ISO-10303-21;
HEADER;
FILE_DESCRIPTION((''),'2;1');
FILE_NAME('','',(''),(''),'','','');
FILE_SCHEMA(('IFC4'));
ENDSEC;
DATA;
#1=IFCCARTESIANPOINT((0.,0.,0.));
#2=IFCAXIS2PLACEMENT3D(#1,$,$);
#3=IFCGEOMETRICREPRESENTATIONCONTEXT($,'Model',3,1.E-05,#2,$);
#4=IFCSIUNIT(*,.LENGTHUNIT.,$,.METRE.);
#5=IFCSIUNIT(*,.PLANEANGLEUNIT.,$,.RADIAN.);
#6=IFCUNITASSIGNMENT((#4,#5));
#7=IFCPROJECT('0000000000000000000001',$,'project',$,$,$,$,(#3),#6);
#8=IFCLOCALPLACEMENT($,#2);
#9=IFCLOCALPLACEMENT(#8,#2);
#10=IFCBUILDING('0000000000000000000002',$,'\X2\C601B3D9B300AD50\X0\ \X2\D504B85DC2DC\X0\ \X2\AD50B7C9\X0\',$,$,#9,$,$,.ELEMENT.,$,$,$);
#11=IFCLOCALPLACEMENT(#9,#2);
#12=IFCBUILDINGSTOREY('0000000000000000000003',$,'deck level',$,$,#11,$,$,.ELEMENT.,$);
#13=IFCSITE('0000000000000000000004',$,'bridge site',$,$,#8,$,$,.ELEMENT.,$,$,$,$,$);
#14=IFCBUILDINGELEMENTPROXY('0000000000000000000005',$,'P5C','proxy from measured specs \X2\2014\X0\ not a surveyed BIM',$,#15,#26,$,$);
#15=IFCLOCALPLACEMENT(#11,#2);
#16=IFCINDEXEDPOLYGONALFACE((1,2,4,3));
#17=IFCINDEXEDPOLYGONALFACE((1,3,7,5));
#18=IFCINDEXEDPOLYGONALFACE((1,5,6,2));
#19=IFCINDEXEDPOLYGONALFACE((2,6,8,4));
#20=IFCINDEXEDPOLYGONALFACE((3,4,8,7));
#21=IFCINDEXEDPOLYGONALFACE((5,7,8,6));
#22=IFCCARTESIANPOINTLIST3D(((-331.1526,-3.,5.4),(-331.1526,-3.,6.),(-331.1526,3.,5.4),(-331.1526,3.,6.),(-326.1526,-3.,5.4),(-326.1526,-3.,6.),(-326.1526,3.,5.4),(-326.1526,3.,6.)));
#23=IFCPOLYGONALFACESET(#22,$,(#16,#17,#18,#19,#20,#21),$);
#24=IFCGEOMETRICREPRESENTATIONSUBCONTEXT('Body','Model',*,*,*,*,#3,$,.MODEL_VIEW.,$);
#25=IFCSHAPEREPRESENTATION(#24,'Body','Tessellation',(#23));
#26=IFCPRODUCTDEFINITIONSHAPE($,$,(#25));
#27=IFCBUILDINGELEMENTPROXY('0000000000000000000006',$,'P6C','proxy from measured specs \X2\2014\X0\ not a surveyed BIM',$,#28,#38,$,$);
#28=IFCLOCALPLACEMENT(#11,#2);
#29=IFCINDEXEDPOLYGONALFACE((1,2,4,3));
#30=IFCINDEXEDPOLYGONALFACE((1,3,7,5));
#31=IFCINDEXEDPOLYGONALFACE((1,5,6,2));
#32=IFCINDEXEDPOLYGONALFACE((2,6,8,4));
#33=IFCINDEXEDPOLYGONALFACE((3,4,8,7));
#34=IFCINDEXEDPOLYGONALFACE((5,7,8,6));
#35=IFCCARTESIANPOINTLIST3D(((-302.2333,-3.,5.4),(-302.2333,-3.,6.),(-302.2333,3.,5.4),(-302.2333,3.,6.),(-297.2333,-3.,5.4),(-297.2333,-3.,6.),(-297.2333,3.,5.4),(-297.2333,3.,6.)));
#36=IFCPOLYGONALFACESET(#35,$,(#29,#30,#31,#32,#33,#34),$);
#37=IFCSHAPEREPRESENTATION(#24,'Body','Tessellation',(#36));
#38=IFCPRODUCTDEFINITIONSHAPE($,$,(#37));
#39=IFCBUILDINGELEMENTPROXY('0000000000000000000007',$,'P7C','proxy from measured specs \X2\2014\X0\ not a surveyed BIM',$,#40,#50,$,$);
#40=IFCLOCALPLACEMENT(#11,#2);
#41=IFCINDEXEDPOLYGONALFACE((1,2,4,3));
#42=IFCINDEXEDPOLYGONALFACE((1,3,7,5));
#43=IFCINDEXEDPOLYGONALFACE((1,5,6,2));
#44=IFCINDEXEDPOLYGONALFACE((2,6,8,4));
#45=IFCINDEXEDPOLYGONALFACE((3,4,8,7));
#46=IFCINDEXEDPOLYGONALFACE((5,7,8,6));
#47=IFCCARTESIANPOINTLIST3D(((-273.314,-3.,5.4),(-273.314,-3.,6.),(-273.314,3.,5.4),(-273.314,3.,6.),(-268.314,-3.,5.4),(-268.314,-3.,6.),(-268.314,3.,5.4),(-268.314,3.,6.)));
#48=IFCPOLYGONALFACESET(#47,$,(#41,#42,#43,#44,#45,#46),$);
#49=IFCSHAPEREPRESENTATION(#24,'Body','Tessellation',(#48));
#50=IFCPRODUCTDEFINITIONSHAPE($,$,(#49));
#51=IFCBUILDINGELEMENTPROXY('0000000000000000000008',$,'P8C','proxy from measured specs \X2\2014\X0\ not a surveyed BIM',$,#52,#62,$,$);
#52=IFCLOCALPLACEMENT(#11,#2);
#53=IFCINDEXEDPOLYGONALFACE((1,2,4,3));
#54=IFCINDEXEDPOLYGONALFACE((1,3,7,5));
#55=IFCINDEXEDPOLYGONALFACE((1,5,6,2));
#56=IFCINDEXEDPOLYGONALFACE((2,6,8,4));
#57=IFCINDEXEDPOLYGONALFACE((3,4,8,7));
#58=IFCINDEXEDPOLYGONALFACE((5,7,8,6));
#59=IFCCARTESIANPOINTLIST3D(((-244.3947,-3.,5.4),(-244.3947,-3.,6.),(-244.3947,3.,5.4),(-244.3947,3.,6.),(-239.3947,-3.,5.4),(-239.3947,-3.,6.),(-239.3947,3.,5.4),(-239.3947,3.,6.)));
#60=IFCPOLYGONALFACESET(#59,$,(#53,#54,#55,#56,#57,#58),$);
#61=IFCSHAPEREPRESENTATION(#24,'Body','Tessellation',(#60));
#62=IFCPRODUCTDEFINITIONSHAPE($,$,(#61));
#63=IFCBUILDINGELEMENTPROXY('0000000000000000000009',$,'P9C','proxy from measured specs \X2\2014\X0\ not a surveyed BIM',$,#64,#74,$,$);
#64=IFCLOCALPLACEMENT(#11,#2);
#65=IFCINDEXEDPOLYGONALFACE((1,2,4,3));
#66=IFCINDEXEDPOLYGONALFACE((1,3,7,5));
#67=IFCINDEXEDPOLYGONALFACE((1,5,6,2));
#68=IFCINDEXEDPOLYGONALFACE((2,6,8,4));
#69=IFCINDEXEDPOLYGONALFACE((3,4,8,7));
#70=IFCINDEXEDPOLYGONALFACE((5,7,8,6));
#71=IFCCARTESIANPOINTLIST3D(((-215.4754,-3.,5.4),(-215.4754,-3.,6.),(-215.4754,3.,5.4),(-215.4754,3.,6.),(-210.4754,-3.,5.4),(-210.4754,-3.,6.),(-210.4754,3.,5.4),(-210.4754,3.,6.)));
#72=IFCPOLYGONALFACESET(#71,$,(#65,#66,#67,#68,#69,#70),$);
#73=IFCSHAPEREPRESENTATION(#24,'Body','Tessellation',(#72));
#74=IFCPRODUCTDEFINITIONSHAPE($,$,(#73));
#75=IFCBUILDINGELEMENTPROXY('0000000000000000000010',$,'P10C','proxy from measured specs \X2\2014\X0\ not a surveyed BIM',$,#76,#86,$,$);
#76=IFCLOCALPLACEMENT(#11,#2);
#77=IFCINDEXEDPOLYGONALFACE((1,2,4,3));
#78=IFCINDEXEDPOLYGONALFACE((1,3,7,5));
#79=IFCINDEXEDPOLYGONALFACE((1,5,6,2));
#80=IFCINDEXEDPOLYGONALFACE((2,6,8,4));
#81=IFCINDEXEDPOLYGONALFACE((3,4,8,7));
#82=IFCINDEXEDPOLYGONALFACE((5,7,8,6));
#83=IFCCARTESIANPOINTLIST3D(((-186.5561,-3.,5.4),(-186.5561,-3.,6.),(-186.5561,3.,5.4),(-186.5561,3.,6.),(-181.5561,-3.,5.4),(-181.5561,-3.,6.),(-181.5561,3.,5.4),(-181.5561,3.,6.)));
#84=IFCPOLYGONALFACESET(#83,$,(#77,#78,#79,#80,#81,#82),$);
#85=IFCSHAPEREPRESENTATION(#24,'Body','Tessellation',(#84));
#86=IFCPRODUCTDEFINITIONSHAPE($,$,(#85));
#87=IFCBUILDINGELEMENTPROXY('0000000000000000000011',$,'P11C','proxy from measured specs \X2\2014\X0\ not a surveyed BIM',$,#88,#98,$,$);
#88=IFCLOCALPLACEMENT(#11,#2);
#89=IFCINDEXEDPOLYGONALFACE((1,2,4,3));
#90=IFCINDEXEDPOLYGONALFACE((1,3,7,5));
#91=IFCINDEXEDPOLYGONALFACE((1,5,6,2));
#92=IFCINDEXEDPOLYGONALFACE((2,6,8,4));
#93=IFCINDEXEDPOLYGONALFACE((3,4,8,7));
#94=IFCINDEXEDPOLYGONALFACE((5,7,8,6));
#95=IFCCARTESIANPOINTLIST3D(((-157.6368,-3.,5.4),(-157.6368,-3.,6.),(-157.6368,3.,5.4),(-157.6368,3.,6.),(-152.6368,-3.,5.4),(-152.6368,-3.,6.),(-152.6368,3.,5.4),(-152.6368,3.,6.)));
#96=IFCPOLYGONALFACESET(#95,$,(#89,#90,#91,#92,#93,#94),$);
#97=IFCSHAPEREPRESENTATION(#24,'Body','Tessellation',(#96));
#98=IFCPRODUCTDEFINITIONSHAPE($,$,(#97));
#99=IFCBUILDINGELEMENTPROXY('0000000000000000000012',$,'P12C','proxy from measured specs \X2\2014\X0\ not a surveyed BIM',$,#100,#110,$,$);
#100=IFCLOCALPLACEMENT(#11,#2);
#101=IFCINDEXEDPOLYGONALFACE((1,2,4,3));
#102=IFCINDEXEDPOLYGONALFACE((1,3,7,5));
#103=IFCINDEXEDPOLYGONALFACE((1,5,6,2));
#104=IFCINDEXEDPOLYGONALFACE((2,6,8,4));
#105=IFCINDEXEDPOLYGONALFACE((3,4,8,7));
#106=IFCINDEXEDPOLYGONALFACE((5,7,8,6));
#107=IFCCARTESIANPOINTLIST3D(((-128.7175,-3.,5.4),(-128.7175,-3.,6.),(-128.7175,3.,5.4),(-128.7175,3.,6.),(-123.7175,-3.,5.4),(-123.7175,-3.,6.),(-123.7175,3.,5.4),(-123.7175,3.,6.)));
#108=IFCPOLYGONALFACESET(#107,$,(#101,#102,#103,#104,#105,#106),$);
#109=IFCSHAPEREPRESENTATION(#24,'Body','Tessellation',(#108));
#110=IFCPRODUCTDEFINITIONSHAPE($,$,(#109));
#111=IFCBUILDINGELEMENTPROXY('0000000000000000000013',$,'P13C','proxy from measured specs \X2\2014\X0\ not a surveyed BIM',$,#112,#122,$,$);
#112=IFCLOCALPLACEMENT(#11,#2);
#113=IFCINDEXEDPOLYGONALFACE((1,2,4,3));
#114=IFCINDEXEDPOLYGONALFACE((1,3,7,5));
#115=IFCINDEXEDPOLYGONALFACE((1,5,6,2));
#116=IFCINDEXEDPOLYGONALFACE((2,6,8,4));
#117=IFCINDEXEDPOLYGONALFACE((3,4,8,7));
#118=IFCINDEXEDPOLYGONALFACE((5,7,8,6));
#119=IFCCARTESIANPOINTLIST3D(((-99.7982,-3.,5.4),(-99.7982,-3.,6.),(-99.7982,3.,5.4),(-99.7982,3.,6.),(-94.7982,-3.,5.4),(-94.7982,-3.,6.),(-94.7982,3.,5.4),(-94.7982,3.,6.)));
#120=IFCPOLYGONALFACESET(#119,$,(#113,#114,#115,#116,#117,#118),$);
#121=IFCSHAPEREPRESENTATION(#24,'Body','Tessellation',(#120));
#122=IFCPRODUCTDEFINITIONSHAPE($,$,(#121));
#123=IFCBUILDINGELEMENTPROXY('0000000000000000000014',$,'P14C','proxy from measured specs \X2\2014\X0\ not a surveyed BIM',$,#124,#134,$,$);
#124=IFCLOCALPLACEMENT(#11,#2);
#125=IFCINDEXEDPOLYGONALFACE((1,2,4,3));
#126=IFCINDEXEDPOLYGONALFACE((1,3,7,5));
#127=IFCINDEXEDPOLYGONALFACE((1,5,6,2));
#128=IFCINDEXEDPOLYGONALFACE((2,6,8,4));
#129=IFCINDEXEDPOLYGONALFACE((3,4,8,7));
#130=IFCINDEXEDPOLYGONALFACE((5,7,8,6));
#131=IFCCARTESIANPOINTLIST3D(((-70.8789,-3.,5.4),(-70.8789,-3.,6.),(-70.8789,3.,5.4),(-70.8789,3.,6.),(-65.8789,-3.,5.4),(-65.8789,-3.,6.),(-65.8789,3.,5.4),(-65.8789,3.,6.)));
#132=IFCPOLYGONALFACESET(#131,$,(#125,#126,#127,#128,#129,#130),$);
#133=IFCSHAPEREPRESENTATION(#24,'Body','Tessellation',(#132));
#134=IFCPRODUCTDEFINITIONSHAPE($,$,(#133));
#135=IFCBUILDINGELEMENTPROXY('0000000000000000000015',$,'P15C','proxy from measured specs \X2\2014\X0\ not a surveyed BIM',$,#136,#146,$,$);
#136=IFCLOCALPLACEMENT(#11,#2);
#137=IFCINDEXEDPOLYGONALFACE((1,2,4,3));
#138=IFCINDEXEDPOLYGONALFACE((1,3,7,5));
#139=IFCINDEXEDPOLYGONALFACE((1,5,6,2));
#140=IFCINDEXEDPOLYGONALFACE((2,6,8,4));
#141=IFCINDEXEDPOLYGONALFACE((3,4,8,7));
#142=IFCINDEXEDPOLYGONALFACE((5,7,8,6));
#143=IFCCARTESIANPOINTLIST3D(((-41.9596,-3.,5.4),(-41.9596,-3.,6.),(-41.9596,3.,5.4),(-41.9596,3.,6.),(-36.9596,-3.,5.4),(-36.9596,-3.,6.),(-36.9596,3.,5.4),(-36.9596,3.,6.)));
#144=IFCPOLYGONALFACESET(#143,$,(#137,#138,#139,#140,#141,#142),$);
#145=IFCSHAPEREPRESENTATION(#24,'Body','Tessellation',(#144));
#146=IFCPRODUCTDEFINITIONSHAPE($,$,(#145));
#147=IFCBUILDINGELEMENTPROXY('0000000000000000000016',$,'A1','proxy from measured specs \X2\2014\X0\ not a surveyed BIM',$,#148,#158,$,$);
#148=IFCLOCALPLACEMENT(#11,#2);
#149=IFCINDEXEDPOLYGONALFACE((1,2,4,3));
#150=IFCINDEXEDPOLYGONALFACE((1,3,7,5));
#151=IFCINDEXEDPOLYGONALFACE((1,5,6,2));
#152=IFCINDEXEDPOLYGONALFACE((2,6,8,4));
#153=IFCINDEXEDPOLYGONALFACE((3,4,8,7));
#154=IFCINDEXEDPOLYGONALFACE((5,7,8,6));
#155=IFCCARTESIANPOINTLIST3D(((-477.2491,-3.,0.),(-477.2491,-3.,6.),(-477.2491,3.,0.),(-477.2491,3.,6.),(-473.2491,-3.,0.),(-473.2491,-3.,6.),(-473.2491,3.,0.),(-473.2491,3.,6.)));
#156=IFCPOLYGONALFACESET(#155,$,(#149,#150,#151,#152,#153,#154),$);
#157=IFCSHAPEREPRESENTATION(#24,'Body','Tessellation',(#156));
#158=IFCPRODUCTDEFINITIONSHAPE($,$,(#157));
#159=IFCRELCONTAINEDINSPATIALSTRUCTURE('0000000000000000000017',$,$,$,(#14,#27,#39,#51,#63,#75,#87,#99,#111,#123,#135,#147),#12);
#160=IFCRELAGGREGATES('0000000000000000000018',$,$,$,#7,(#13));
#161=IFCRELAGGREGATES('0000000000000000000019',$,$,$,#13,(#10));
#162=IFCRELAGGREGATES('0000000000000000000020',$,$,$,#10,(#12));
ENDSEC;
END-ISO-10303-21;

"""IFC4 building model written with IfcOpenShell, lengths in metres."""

from ifc_helpers import new_model, si_unit, frame, origin, origin_2d, place, context, subcontext, project, spatial, rectangle, extrude, element, save


model = new_model("IFC4")

# Units and contexts
model_context = context("Model", 3, precision=1e-05, world=origin())
body_context = subcontext(model_context, "Body", "Model", "MODEL_VIEW")
ifc_project = project(units=[si_unit("LENGTHUNIT", "METRE"), si_unit("PLANEANGLEUNIT", "RADIAN")], contexts=[model_context])

# Site, building, storey
site_placement = place(None, origin())
site = spatial("IfcSite", under=ifc_project, at=site_placement, Name="bridge site", CompositionType="ELEMENT")
building_placement = place(site_placement, origin())
building = spatial("IfcBuilding", under=site, at=building_placement, Name="영동대교 프록시 교량", CompositionType="ELEMENT")
storey_placement = place(building_placement, origin())
storey = spatial("IfcBuildingStorey", under=building, at=storey_placement, Name="deck level", CompositionType="ELEMENT")

# Building element proxies
for number, where, name in (
    (1, (-328.6526, 0.0, 5.4), "P5C"),
    (2, (-299.7333, 0.0, 5.4), "P6C"),
    (3, (-270.814, 0.0, 5.4), "P7C"),
    (4, (-241.8947, 0.0, 5.4), "P8C"),
    (5, (-212.9754, 0.0, 5.4), "P9C"),
    (6, (-184.0561, 0.0, 5.4), "P10C"),
    (7, (-155.1368, 0.0, 5.4), "P11C"),
):
    element("IfcBuildingElementProxy", number, at=place(storey_placement, frame(where)), inside=storey, Name=name, Description="proxy from measured specs — not a surveyed BIM", context=body_context, shape_type="SweptSolid", body=[
        extrude(rectangle(XDim=5.0, YDim=6.0, at=origin_2d()), origin(), (0.0, 0.0, 1.0), 0.6),
    ])
proxy_1_placement = place(storey_placement, frame((-126.2175, 0.0, 5.4)))
element("IfcBuildingElementProxy", 8, at=proxy_1_placement, inside=storey, Name="P12C", Description="proxy from measured specs — not a surveyed BIM", context=body_context, shape_type="SweptSolid", body=[
    extrude(rectangle(XDim=5.0, YDim=6.0, at=origin_2d()), origin(), (0.0, 0.0, 1.0), 0.6),
])
for number, where, name in (
    (9, (-97.2982, 0.0, 5.4), "P13C"),
    (10, (-68.3789, 0.0, 5.4), "P14C"),
    (11, (-39.4596, 0.0, 5.4), "P15C"),
):
    element("IfcBuildingElementProxy", number, at=place(storey_placement, frame(where)), inside=storey, Name=name, Description="proxy from measured specs — not a surveyed BIM", context=body_context, shape_type="SweptSolid", body=[
        extrude(rectangle(XDim=5.0, YDim=6.0, at=origin_2d()), origin(), (0.0, 0.0, 1.0), 0.6),
    ])
proxy_2_placement = place(storey_placement, frame((-475.2491, 0.0, 0.0)))
element("IfcBuildingElementProxy", 12, at=proxy_2_placement, inside=storey, Name="A1", Description="proxy from measured specs — not a surveyed BIM", context=body_context, shape_type="SweptSolid", body=[
    extrude(rectangle(XDim=4.0, YDim=6.0, at=origin_2d()), origin(), (0.0, 0.0, 1.0), 6.0),
])

save(model, "model.ifc")
